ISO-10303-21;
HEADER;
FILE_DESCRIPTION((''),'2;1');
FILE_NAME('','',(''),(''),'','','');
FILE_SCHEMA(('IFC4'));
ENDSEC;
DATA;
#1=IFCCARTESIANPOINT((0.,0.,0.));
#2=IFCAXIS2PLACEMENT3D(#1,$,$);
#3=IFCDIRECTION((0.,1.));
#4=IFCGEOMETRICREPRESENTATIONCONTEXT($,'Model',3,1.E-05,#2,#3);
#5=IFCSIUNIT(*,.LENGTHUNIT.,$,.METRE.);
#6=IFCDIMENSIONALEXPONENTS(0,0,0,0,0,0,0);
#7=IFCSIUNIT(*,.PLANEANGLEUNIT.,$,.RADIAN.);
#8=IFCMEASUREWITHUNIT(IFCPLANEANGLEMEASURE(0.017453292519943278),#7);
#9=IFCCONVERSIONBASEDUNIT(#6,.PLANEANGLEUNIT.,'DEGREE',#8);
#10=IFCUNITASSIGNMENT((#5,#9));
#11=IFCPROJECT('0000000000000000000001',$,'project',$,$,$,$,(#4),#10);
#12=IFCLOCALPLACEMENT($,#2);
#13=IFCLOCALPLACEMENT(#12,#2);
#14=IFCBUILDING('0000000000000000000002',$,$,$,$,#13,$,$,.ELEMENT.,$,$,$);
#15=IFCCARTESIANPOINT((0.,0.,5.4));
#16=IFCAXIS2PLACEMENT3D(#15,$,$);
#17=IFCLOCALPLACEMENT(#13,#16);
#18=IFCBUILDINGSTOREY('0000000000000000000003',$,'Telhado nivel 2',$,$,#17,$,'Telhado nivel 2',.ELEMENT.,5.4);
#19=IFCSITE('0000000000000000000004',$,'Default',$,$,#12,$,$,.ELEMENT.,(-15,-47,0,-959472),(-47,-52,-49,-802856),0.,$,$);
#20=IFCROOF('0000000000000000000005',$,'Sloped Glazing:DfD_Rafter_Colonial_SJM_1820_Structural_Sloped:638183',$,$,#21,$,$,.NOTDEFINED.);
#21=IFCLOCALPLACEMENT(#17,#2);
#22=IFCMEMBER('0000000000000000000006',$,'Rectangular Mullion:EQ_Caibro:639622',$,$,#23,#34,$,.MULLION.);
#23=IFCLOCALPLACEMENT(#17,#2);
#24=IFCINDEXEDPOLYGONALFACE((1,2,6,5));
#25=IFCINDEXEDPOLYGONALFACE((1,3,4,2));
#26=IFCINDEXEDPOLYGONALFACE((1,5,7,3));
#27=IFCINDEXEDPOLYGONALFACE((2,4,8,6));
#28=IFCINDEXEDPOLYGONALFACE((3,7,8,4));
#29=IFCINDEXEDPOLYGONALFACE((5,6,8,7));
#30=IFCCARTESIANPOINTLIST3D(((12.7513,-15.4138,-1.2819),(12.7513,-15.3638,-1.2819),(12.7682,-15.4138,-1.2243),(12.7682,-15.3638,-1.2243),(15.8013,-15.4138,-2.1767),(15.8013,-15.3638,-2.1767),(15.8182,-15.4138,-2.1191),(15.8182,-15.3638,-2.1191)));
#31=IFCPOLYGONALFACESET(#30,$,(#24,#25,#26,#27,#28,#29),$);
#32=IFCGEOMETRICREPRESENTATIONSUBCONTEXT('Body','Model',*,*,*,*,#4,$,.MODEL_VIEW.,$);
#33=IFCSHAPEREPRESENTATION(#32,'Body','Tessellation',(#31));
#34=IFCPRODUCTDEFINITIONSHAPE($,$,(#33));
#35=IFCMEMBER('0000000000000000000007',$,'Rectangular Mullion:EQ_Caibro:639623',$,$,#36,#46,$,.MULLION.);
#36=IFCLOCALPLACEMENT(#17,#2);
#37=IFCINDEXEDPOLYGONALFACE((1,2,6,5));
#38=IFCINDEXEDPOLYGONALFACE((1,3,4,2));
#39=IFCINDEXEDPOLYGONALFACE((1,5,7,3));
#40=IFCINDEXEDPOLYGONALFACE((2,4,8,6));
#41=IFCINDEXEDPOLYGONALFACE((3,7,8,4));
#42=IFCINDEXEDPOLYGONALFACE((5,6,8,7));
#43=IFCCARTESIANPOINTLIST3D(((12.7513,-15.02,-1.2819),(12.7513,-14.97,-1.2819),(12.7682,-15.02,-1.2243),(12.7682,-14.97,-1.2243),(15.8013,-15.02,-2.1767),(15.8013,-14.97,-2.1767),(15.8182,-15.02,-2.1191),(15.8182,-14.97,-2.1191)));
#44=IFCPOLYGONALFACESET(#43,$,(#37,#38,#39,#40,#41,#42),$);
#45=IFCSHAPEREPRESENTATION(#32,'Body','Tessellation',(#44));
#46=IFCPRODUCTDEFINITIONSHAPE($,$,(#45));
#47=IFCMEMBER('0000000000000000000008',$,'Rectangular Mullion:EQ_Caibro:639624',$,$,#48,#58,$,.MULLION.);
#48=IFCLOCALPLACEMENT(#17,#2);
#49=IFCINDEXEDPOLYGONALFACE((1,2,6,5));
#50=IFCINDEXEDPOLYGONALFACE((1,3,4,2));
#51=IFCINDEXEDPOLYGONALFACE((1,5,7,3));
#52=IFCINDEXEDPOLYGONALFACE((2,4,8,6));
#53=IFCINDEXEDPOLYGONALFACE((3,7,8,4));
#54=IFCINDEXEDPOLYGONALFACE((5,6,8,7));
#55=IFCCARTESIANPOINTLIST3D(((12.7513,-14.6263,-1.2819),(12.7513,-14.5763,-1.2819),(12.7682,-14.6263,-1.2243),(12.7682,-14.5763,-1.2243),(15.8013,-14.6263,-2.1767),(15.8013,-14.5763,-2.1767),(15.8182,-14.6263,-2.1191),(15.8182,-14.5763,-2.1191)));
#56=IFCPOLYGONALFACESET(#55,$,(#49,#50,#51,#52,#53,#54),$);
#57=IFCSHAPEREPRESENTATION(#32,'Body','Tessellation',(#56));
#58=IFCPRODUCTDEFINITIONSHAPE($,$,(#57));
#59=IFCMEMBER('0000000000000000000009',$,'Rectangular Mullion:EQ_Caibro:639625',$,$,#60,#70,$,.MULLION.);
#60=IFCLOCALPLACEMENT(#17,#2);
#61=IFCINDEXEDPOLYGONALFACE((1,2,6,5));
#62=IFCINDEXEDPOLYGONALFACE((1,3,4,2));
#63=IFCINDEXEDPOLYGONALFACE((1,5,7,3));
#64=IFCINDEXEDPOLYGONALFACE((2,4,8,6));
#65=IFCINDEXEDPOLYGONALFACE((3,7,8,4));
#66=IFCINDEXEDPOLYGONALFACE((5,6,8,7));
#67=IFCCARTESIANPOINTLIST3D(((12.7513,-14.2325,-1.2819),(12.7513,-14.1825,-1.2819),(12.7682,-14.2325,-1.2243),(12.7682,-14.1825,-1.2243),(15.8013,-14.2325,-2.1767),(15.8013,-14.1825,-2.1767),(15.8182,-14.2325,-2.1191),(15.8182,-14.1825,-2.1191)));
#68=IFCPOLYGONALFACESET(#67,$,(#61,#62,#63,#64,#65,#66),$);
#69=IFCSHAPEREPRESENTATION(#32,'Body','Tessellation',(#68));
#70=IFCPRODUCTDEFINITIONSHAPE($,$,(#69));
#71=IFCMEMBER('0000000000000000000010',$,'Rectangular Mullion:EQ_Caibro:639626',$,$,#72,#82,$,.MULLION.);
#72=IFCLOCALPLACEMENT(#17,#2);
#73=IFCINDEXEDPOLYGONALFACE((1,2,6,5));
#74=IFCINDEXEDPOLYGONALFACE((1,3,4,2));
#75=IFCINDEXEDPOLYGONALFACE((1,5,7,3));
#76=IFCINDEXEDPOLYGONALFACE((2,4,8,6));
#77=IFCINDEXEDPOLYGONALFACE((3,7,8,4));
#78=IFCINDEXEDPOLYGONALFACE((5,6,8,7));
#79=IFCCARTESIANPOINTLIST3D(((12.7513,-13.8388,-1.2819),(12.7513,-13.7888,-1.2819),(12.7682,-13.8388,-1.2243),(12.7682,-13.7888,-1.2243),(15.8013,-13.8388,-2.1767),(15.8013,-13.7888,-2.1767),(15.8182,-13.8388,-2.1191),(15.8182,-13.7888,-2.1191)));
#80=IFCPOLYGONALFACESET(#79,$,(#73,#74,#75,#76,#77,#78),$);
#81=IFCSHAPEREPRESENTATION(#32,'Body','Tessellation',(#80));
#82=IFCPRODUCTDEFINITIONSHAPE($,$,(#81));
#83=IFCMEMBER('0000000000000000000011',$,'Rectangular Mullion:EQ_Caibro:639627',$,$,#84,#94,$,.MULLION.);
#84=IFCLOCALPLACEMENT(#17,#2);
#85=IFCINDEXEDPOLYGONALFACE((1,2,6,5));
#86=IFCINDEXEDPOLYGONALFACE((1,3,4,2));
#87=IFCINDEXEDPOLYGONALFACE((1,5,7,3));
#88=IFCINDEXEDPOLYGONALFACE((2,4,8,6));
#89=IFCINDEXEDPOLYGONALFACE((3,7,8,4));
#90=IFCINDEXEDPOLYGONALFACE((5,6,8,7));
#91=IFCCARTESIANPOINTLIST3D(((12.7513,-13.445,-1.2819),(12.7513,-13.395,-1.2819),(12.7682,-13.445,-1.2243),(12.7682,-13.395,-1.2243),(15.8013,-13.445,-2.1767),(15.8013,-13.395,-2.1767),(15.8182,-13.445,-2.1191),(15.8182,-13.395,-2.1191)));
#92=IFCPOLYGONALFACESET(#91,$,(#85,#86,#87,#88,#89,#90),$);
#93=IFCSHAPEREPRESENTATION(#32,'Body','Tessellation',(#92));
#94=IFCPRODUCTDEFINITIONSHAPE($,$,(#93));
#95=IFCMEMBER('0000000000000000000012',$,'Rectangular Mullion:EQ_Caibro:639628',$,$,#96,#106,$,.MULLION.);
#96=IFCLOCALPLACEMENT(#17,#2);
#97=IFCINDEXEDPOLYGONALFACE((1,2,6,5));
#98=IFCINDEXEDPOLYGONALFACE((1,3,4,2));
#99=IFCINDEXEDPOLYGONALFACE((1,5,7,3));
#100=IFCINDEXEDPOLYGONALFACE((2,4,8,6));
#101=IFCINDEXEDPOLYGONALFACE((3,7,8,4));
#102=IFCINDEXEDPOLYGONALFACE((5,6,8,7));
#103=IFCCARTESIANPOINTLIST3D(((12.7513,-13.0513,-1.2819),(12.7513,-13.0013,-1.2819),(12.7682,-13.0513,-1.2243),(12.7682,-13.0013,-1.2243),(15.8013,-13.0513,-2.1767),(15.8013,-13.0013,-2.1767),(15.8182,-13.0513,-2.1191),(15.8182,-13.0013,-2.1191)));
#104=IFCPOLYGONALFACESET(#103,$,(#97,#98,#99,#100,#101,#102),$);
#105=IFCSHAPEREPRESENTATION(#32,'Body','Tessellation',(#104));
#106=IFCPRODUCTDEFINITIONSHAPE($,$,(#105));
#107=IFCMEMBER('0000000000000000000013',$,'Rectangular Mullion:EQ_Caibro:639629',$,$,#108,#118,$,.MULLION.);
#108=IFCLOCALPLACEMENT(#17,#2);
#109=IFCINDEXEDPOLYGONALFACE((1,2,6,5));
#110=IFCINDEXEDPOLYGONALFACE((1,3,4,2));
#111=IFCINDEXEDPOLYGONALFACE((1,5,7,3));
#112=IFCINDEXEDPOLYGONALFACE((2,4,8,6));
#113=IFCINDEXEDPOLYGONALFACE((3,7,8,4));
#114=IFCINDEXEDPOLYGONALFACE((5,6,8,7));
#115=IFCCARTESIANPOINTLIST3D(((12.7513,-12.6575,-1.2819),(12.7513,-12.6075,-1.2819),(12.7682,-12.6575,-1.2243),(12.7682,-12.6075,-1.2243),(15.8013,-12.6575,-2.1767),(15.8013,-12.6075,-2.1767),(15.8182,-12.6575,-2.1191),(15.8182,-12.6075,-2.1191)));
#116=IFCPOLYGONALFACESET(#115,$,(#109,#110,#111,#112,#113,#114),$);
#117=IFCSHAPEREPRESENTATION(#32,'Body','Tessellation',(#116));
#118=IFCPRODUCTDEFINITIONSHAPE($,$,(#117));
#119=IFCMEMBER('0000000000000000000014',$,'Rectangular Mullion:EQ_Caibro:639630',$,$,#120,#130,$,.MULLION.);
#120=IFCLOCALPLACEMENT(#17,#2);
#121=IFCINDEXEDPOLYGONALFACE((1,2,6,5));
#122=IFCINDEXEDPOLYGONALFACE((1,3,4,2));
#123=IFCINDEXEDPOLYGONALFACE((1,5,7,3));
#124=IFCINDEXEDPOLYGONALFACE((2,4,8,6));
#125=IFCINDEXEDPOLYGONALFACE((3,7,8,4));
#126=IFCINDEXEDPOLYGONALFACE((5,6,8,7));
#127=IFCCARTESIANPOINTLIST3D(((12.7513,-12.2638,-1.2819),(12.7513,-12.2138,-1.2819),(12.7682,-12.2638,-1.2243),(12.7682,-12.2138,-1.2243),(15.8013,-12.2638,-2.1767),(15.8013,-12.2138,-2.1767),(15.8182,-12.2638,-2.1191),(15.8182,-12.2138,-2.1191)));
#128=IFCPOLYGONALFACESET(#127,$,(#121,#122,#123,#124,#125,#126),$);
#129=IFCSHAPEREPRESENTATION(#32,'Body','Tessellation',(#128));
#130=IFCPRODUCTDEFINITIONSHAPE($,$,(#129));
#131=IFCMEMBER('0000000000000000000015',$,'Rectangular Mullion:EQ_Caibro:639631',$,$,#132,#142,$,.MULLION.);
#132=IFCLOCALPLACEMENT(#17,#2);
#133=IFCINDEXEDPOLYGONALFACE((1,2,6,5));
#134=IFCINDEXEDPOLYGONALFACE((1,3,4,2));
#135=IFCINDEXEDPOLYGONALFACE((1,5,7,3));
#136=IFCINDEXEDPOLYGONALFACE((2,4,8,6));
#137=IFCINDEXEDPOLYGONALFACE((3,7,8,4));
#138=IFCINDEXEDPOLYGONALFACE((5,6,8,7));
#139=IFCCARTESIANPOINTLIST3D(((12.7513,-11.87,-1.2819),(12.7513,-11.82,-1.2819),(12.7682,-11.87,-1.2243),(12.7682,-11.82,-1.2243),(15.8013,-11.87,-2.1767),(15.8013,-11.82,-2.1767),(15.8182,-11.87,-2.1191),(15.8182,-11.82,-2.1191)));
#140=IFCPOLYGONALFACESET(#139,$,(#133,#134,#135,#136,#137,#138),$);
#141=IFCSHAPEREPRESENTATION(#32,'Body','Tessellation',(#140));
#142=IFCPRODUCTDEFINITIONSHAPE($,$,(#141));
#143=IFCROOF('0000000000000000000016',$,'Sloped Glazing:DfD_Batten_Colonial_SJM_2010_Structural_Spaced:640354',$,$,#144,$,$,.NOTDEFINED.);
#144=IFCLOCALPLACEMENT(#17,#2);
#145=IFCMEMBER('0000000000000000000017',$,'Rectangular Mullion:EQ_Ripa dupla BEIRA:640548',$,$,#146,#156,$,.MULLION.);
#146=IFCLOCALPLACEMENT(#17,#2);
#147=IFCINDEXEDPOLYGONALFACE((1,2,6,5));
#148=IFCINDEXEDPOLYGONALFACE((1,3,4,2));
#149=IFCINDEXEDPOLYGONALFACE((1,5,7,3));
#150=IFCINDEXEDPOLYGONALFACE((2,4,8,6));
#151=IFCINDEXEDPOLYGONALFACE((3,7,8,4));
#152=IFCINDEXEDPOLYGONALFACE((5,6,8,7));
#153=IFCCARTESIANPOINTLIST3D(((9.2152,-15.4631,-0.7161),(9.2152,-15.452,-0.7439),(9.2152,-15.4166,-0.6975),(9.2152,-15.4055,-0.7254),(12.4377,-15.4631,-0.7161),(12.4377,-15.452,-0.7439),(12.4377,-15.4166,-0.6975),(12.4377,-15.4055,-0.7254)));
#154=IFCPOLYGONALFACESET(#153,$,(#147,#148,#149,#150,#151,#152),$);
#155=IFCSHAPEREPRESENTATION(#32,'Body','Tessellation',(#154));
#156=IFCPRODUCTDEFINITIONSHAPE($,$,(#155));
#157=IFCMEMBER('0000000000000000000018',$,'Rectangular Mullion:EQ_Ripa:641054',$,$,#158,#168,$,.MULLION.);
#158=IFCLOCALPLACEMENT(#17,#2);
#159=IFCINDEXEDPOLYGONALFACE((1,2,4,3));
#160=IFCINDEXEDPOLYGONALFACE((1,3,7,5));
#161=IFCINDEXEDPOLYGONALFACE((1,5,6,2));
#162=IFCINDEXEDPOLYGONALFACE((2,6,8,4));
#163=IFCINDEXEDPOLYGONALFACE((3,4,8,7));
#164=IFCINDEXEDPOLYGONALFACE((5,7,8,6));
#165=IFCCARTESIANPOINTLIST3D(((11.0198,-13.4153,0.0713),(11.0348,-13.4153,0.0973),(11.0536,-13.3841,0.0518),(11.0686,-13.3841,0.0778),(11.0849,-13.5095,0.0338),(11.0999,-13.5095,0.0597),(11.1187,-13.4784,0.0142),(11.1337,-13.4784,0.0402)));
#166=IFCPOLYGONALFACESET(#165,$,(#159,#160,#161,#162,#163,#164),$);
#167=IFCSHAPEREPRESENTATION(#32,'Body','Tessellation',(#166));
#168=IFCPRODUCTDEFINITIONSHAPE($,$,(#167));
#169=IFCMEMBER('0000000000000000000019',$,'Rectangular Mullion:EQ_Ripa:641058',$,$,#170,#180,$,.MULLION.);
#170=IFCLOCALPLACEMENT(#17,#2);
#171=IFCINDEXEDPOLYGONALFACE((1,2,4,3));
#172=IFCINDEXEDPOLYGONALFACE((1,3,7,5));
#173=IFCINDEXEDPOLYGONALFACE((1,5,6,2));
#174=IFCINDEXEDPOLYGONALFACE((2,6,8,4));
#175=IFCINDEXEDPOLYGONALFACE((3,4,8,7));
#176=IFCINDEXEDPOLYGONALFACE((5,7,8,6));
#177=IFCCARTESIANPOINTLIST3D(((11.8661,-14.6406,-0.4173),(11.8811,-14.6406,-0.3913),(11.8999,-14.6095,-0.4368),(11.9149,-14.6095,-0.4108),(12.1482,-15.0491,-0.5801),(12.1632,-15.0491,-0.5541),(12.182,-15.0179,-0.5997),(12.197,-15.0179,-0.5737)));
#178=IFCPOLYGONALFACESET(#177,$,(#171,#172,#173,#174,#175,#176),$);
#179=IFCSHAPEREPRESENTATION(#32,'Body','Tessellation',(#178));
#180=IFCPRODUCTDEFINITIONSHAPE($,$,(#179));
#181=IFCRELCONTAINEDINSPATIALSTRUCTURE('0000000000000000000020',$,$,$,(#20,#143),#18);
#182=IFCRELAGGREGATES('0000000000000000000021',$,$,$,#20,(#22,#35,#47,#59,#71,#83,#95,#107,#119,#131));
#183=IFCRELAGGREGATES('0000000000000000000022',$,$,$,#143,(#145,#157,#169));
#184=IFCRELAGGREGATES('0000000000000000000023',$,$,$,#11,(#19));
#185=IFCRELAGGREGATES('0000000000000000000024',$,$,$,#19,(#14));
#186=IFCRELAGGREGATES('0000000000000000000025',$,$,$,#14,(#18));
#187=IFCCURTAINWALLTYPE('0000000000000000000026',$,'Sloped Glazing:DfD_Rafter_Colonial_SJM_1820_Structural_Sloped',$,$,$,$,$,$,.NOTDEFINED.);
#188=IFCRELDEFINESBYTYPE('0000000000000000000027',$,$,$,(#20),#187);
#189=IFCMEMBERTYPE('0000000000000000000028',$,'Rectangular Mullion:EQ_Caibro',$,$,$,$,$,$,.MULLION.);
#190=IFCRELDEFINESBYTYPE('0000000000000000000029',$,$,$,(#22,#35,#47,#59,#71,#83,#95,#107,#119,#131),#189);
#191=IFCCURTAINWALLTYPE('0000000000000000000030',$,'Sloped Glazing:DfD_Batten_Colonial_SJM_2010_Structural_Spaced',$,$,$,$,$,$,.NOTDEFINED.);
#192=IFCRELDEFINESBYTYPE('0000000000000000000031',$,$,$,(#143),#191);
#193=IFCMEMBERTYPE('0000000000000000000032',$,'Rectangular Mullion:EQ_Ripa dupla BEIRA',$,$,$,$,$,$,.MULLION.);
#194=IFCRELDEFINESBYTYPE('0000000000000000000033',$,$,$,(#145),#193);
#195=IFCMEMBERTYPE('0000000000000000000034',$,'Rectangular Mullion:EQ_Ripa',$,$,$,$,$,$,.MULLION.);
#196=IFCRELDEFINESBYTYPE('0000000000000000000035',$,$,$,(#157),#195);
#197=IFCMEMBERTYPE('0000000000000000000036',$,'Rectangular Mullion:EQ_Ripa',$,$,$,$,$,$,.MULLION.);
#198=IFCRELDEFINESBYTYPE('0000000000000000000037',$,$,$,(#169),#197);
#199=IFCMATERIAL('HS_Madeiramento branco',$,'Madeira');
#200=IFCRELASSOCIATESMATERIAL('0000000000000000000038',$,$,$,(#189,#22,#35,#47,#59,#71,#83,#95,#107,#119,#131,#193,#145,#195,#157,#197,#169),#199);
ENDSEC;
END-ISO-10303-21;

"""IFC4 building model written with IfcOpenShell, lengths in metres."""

from ifc_helpers import new_model, entity, si_unit, converted_unit, direction, frame, origin, place, context, subcontext, project, spatial, indexed_curve, outline, extrude, source, transform, mapped, material, type_object, type_shapes, element, aggregate, save


model = new_model("IFC4")

# Units and contexts
model_context = context("Model", 3, precision=1e-05, world=origin(), true_north=direction((0.0, 1.0)))
body_context = subcontext(model_context, "Body", "Model", "MODEL_VIEW")
ifc_project = project(units=[si_unit("LENGTHUNIT", "METRE"), converted_unit("PLANEANGLEUNIT", "DEGREE", entity("IfcPlaneAngleMeasure", 0.017453292519943278), si_unit("PLANEANGLEUNIT", "RADIAN"), dimensions=[0, 0, 0, 0, 0, 0, 0])], contexts=[model_context])

# Site, building, storey
site_placement = place(None, origin())
site = spatial("IfcSite", under=ifc_project, at=site_placement, Name="Default", CompositionType="ELEMENT", RefLatitude=(-15, -47, 0, -959472), RefLongitude=(-47, -52, -49, -802856), RefElevation=0.0)
building_placement = place(site_placement, origin())
building = spatial("IfcBuilding", under=site, at=building_placement, CompositionType="ELEMENT")
storey_placement = place(building_placement, frame((0.0, 0.0, 5.4)))
storey = spatial("IfcBuildingStorey", under=building, at=storey_placement, Name="Telhado nivel 2", LongName="Telhado nivel 2", CompositionType="ELEMENT", Elevation=5.4)

# Roofs, members
curtain_wall_type_1 = type_object("IfcCurtainWallType", Name="Sloped Glazing:DfD_Rafter_Colonial_SJM_1820_Structural_Sloped", PredefinedType="NOTDEFINED")
roof_1_placement = place(storey_placement, frame((0.0, 0.0, -5.4)))
roof_1 = element("IfcRoof", 1, at=roof_1_placement, inside=storey, type_object=curtain_wall_type_1, Name="Sloped Glazing:DfD_Rafter_Colonial_SJM_1820_Structural_Sloped:638183", PredefinedType="NOTDEFINED")
ifc_material = material(Name="HS_Madeiramento branco", Category="Madeira")
member_type_1 = type_object("IfcMemberType", Name="Rectangular Mullion:EQ_Caibro", PredefinedType="MULLION", material=ifc_material)
shared_shape_1 = source(origin(), body_context, "Body", "SweptSolid", [
    extrude(outline(indexed_curve([(-0.025, -0.03), (0.025, -0.03), (0.025, 0.03), (-0.025, 0.03), (-0.025, -0.03)], self_intersect=False)), frame((0.0, -0.03, -3.1785), z_axis=(0.0, 0.0, 1.0), x_axis=(-1.0, 0.0, 0.0)), (0.0, 0.0, 1.0), 3.1785),
])
type_shapes(member_type_1, [shared_shape_1])
member_1_placement = place(roof_1_placement, frame((12.7513, -15.3888, 4.1181), z_axis=(-0.95956, 0.0, 0.281504), x_axis=(0.0, 1.0, 0.0)))
member_1 = element("IfcMember", 2, at=member_1_placement, type_object=member_type_1, material=ifc_material, Name="Rectangular Mullion:EQ_Caibro:639622", PredefinedType="MULLION", context=body_context, shape_type="MappedRepresentation", body=[
    mapped(shared_shape_1, transform((0.0, 0.0, 0.0), scale=1.0)),
])
member_2_placement = place(roof_1_placement, frame((12.7513, -14.995, 4.1181), z_axis=(-0.95956, 0.0, 0.281504), x_axis=(0.0, 1.0, 0.0)))
member_2 = element("IfcMember", 3, at=member_2_placement, type_object=member_type_1, material=ifc_material, Name="Rectangular Mullion:EQ_Caibro:639623", PredefinedType="MULLION", context=body_context, shape_type="MappedRepresentation", body=[
    mapped(shared_shape_1, transform((0.0, 0.0, 0.0), scale=1.0)),
])
member_3_placement = place(roof_1_placement, frame((12.7513, -14.6013, 4.1181), z_axis=(-0.95956, 0.0, 0.281504), x_axis=(0.0, 1.0, 0.0)))
member_3 = element("IfcMember", 4, at=member_3_placement, type_object=member_type_1, material=ifc_material, Name="Rectangular Mullion:EQ_Caibro:639624", PredefinedType="MULLION", context=body_context, shape_type="MappedRepresentation", body=[
    mapped(shared_shape_1, transform((0.0, 0.0, 0.0), scale=1.0)),
])
member_4_placement = place(roof_1_placement, frame((12.7513, -14.2075, 4.1181), z_axis=(-0.95956, 0.0, 0.281504), x_axis=(0.0, 1.0, 0.0)))
member_4 = element("IfcMember", 5, at=member_4_placement, type_object=member_type_1, material=ifc_material, Name="Rectangular Mullion:EQ_Caibro:639625", PredefinedType="MULLION", context=body_context, shape_type="MappedRepresentation", body=[
    mapped(shared_shape_1, transform((0.0, 0.0, 0.0), scale=1.0)),
])
member_5_placement = place(roof_1_placement, frame((12.7513, -13.8138, 4.1181), z_axis=(-0.95956, 0.0, 0.281504), x_axis=(0.0, 1.0, 0.0)))
member_5 = element("IfcMember", 6, at=member_5_placement, type_object=member_type_1, material=ifc_material, Name="Rectangular Mullion:EQ_Caibro:639626", PredefinedType="MULLION", context=body_context, shape_type="MappedRepresentation", body=[
    mapped(shared_shape_1, transform((0.0, 0.0, 0.0), scale=1.0)),
])
member_6_placement = place(roof_1_placement, frame((12.7513, -13.42, 4.1181), z_axis=(-0.95956, 0.0, 0.281504), x_axis=(0.0, 1.0, 0.0)))
member_6 = element("IfcMember", 7, at=member_6_placement, type_object=member_type_1, material=ifc_material, Name="Rectangular Mullion:EQ_Caibro:639627", PredefinedType="MULLION", context=body_context, shape_type="MappedRepresentation", body=[
    mapped(shared_shape_1, transform((0.0, 0.0, 0.0), scale=1.0)),
])
member_7_placement = place(roof_1_placement, frame((12.7513, -13.0263, 4.1181), z_axis=(-0.95956, 0.0, 0.281504), x_axis=(0.0, 1.0, 0.0)))
member_7 = element("IfcMember", 8, at=member_7_placement, type_object=member_type_1, material=ifc_material, Name="Rectangular Mullion:EQ_Caibro:639628", PredefinedType="MULLION", context=body_context, shape_type="MappedRepresentation", body=[
    mapped(shared_shape_1, transform((0.0, 0.0, 0.0), scale=1.0)),
])
member_8_placement = place(roof_1_placement, frame((12.7513, -12.6325, 4.1181), z_axis=(-0.95956, 0.0, 0.281504), x_axis=(0.0, 1.0, 0.0)))
member_8 = element("IfcMember", 9, at=member_8_placement, type_object=member_type_1, material=ifc_material, Name="Rectangular Mullion:EQ_Caibro:639629", PredefinedType="MULLION", context=body_context, shape_type="MappedRepresentation", body=[
    mapped(shared_shape_1, transform((0.0, 0.0, 0.0), scale=1.0)),
])
member_9_placement = place(roof_1_placement, frame((12.7513, -12.2388, 4.1181), z_axis=(-0.95956, 0.0, 0.281504), x_axis=(0.0, 1.0, 0.0)))
member_9 = element("IfcMember", 10, at=member_9_placement, type_object=member_type_1, material=ifc_material, Name="Rectangular Mullion:EQ_Caibro:639630", PredefinedType="MULLION", context=body_context, shape_type="MappedRepresentation", body=[
    mapped(shared_shape_1, transform((0.0, 0.0, 0.0), scale=1.0)),
])
member_10_placement = place(roof_1_placement, frame((12.7513, -11.845, 4.1181), z_axis=(-0.95956, 0.0, 0.281504), x_axis=(0.0, 1.0, 0.0)))
member_10 = element("IfcMember", 11, at=member_10_placement, type_object=member_type_1, material=ifc_material, Name="Rectangular Mullion:EQ_Caibro:639631", PredefinedType="MULLION", context=body_context, shape_type="MappedRepresentation", body=[
    mapped(shared_shape_1, transform((0.0, 0.0, 0.0), scale=1.0)),
])
aggregate(roof_1, [member_1, member_2, member_3, member_4, member_5, member_6, member_7, member_8, member_9, member_10])
curtain_wall_type_2 = type_object("IfcCurtainWallType", Name="Sloped Glazing:DfD_Batten_Colonial_SJM_2010_Structural_Spaced", PredefinedType="NOTDEFINED")
roof_2_placement = place(storey_placement, frame((0.0, 0.0, -5.4)))
roof_2 = element("IfcRoof", 12, at=roof_2_placement, inside=storey, type_object=curtain_wall_type_2, Name="Sloped Glazing:DfD_Batten_Colonial_SJM_2010_Structural_Spaced:640354", PredefinedType="NOTDEFINED")
member_type_2 = type_object("IfcMemberType", Name="Rectangular Mullion:EQ_Ripa dupla BEIRA", PredefinedType="MULLION", material=ifc_material)
shared_shape_2 = source(origin(), body_context, "Body", "SweptSolid", [
    extrude(outline(indexed_curve([(-0.025, -0.015), (0.025, -0.015), (0.025, 0.015), (-0.025, 0.015), (-0.025, -0.015)], self_intersect=False)), frame((-0.025, 0.0, -3.2226), z_axis=(0.0, 0.0, 1.0), x_axis=(-1.0, 0.0, 0.0)), (0.0, 0.0, 1.0), 3.2226),
])
type_shapes(member_type_2, [shared_shape_2])
member_11_placement = place(roof_2_placement, frame((12.4377, -15.4575, 4.67), z_axis=(1.0, 0.0, 0.0), x_axis=(0.0, -0.928878, -0.370385)))
member_11 = element("IfcMember", 13, at=member_11_placement, type_object=member_type_2, material=ifc_material, Name="Rectangular Mullion:EQ_Ripa dupla BEIRA:640548", PredefinedType="MULLION", context=body_context, shape_type="MappedRepresentation", body=[
    mapped(shared_shape_2, transform((0.0, 0.0, 0.0), scale=1.0)),
])
member_type_3 = type_object("IfcMemberType", Name="Rectangular Mullion:EQ_Ripa", PredefinedType="MULLION", material=ifc_material)
shared_shape_3 = source(origin(), body_context, "Body", "SweptSolid", [
    extrude(outline(indexed_curve([(-0.025, -0.015), (0.025, -0.015), (0.025, 0.015), (-0.025, 0.015), (-0.025, -0.015)], self_intersect=False)), frame((-0.025, 0.0, -0.1205), z_axis=(0.0, 0.0, 1.0), x_axis=(-1.0, 0.0, 0.0)), (0.0, 0.0, 1.0), 0.1205),
])
type_shapes(member_type_3, [shared_shape_3])
member_12_placement = place(roof_2_placement, frame((11.0924, -13.5095, 5.4468), z_axis=(0.539965, -0.781825, -0.311749), x_axis=(-0.67708, -0.623498, 0.390913)))
member_12 = element("IfcMember", 14, at=member_12_placement, type_object=member_type_3, material=ifc_material, Name="Rectangular Mullion:EQ_Ripa:641054", PredefinedType="MULLION", context=body_context, shape_type="MappedRepresentation", body=[
    mapped(shared_shape_3, transform((0.0, 0.0, 0.0), scale=1.0)),
])
member_type_4 = type_object("IfcMemberType", Name="Rectangular Mullion:EQ_Ripa", PredefinedType="MULLION", material=ifc_material)
shared_shape_4 = source(origin(), body_context, "Body", "SweptSolid", [
    extrude(outline(indexed_curve([(-0.025, -0.015), (0.025, -0.015), (0.025, 0.015), (-0.025, 0.015), (-0.025, -0.015)], self_intersect=False)), frame((-0.025, 0.0, -0.5224), z_axis=(0.0, 0.0, 1.0), x_axis=(-1.0, 0.0, 0.0)), (0.0, 0.0, 1.0), 0.5224),
])
type_shapes(member_type_4, [shared_shape_4])
member_13_placement = place(roof_2_placement, frame((12.1557, -15.0491, 4.8329), z_axis=(0.539965, -0.781825, -0.311749), x_axis=(-0.67708, -0.623498, 0.390913)))
member_13 = element("IfcMember", 15, at=member_13_placement, type_object=member_type_4, material=ifc_material, Name="Rectangular Mullion:EQ_Ripa:641058", PredefinedType="MULLION", context=body_context, shape_type="MappedRepresentation", body=[
    mapped(shared_shape_4, transform((0.0, 0.0, 0.0), scale=1.0)),
])
aggregate(roof_2, [member_11, member_12, member_13])

save(model, "model.ifc")
